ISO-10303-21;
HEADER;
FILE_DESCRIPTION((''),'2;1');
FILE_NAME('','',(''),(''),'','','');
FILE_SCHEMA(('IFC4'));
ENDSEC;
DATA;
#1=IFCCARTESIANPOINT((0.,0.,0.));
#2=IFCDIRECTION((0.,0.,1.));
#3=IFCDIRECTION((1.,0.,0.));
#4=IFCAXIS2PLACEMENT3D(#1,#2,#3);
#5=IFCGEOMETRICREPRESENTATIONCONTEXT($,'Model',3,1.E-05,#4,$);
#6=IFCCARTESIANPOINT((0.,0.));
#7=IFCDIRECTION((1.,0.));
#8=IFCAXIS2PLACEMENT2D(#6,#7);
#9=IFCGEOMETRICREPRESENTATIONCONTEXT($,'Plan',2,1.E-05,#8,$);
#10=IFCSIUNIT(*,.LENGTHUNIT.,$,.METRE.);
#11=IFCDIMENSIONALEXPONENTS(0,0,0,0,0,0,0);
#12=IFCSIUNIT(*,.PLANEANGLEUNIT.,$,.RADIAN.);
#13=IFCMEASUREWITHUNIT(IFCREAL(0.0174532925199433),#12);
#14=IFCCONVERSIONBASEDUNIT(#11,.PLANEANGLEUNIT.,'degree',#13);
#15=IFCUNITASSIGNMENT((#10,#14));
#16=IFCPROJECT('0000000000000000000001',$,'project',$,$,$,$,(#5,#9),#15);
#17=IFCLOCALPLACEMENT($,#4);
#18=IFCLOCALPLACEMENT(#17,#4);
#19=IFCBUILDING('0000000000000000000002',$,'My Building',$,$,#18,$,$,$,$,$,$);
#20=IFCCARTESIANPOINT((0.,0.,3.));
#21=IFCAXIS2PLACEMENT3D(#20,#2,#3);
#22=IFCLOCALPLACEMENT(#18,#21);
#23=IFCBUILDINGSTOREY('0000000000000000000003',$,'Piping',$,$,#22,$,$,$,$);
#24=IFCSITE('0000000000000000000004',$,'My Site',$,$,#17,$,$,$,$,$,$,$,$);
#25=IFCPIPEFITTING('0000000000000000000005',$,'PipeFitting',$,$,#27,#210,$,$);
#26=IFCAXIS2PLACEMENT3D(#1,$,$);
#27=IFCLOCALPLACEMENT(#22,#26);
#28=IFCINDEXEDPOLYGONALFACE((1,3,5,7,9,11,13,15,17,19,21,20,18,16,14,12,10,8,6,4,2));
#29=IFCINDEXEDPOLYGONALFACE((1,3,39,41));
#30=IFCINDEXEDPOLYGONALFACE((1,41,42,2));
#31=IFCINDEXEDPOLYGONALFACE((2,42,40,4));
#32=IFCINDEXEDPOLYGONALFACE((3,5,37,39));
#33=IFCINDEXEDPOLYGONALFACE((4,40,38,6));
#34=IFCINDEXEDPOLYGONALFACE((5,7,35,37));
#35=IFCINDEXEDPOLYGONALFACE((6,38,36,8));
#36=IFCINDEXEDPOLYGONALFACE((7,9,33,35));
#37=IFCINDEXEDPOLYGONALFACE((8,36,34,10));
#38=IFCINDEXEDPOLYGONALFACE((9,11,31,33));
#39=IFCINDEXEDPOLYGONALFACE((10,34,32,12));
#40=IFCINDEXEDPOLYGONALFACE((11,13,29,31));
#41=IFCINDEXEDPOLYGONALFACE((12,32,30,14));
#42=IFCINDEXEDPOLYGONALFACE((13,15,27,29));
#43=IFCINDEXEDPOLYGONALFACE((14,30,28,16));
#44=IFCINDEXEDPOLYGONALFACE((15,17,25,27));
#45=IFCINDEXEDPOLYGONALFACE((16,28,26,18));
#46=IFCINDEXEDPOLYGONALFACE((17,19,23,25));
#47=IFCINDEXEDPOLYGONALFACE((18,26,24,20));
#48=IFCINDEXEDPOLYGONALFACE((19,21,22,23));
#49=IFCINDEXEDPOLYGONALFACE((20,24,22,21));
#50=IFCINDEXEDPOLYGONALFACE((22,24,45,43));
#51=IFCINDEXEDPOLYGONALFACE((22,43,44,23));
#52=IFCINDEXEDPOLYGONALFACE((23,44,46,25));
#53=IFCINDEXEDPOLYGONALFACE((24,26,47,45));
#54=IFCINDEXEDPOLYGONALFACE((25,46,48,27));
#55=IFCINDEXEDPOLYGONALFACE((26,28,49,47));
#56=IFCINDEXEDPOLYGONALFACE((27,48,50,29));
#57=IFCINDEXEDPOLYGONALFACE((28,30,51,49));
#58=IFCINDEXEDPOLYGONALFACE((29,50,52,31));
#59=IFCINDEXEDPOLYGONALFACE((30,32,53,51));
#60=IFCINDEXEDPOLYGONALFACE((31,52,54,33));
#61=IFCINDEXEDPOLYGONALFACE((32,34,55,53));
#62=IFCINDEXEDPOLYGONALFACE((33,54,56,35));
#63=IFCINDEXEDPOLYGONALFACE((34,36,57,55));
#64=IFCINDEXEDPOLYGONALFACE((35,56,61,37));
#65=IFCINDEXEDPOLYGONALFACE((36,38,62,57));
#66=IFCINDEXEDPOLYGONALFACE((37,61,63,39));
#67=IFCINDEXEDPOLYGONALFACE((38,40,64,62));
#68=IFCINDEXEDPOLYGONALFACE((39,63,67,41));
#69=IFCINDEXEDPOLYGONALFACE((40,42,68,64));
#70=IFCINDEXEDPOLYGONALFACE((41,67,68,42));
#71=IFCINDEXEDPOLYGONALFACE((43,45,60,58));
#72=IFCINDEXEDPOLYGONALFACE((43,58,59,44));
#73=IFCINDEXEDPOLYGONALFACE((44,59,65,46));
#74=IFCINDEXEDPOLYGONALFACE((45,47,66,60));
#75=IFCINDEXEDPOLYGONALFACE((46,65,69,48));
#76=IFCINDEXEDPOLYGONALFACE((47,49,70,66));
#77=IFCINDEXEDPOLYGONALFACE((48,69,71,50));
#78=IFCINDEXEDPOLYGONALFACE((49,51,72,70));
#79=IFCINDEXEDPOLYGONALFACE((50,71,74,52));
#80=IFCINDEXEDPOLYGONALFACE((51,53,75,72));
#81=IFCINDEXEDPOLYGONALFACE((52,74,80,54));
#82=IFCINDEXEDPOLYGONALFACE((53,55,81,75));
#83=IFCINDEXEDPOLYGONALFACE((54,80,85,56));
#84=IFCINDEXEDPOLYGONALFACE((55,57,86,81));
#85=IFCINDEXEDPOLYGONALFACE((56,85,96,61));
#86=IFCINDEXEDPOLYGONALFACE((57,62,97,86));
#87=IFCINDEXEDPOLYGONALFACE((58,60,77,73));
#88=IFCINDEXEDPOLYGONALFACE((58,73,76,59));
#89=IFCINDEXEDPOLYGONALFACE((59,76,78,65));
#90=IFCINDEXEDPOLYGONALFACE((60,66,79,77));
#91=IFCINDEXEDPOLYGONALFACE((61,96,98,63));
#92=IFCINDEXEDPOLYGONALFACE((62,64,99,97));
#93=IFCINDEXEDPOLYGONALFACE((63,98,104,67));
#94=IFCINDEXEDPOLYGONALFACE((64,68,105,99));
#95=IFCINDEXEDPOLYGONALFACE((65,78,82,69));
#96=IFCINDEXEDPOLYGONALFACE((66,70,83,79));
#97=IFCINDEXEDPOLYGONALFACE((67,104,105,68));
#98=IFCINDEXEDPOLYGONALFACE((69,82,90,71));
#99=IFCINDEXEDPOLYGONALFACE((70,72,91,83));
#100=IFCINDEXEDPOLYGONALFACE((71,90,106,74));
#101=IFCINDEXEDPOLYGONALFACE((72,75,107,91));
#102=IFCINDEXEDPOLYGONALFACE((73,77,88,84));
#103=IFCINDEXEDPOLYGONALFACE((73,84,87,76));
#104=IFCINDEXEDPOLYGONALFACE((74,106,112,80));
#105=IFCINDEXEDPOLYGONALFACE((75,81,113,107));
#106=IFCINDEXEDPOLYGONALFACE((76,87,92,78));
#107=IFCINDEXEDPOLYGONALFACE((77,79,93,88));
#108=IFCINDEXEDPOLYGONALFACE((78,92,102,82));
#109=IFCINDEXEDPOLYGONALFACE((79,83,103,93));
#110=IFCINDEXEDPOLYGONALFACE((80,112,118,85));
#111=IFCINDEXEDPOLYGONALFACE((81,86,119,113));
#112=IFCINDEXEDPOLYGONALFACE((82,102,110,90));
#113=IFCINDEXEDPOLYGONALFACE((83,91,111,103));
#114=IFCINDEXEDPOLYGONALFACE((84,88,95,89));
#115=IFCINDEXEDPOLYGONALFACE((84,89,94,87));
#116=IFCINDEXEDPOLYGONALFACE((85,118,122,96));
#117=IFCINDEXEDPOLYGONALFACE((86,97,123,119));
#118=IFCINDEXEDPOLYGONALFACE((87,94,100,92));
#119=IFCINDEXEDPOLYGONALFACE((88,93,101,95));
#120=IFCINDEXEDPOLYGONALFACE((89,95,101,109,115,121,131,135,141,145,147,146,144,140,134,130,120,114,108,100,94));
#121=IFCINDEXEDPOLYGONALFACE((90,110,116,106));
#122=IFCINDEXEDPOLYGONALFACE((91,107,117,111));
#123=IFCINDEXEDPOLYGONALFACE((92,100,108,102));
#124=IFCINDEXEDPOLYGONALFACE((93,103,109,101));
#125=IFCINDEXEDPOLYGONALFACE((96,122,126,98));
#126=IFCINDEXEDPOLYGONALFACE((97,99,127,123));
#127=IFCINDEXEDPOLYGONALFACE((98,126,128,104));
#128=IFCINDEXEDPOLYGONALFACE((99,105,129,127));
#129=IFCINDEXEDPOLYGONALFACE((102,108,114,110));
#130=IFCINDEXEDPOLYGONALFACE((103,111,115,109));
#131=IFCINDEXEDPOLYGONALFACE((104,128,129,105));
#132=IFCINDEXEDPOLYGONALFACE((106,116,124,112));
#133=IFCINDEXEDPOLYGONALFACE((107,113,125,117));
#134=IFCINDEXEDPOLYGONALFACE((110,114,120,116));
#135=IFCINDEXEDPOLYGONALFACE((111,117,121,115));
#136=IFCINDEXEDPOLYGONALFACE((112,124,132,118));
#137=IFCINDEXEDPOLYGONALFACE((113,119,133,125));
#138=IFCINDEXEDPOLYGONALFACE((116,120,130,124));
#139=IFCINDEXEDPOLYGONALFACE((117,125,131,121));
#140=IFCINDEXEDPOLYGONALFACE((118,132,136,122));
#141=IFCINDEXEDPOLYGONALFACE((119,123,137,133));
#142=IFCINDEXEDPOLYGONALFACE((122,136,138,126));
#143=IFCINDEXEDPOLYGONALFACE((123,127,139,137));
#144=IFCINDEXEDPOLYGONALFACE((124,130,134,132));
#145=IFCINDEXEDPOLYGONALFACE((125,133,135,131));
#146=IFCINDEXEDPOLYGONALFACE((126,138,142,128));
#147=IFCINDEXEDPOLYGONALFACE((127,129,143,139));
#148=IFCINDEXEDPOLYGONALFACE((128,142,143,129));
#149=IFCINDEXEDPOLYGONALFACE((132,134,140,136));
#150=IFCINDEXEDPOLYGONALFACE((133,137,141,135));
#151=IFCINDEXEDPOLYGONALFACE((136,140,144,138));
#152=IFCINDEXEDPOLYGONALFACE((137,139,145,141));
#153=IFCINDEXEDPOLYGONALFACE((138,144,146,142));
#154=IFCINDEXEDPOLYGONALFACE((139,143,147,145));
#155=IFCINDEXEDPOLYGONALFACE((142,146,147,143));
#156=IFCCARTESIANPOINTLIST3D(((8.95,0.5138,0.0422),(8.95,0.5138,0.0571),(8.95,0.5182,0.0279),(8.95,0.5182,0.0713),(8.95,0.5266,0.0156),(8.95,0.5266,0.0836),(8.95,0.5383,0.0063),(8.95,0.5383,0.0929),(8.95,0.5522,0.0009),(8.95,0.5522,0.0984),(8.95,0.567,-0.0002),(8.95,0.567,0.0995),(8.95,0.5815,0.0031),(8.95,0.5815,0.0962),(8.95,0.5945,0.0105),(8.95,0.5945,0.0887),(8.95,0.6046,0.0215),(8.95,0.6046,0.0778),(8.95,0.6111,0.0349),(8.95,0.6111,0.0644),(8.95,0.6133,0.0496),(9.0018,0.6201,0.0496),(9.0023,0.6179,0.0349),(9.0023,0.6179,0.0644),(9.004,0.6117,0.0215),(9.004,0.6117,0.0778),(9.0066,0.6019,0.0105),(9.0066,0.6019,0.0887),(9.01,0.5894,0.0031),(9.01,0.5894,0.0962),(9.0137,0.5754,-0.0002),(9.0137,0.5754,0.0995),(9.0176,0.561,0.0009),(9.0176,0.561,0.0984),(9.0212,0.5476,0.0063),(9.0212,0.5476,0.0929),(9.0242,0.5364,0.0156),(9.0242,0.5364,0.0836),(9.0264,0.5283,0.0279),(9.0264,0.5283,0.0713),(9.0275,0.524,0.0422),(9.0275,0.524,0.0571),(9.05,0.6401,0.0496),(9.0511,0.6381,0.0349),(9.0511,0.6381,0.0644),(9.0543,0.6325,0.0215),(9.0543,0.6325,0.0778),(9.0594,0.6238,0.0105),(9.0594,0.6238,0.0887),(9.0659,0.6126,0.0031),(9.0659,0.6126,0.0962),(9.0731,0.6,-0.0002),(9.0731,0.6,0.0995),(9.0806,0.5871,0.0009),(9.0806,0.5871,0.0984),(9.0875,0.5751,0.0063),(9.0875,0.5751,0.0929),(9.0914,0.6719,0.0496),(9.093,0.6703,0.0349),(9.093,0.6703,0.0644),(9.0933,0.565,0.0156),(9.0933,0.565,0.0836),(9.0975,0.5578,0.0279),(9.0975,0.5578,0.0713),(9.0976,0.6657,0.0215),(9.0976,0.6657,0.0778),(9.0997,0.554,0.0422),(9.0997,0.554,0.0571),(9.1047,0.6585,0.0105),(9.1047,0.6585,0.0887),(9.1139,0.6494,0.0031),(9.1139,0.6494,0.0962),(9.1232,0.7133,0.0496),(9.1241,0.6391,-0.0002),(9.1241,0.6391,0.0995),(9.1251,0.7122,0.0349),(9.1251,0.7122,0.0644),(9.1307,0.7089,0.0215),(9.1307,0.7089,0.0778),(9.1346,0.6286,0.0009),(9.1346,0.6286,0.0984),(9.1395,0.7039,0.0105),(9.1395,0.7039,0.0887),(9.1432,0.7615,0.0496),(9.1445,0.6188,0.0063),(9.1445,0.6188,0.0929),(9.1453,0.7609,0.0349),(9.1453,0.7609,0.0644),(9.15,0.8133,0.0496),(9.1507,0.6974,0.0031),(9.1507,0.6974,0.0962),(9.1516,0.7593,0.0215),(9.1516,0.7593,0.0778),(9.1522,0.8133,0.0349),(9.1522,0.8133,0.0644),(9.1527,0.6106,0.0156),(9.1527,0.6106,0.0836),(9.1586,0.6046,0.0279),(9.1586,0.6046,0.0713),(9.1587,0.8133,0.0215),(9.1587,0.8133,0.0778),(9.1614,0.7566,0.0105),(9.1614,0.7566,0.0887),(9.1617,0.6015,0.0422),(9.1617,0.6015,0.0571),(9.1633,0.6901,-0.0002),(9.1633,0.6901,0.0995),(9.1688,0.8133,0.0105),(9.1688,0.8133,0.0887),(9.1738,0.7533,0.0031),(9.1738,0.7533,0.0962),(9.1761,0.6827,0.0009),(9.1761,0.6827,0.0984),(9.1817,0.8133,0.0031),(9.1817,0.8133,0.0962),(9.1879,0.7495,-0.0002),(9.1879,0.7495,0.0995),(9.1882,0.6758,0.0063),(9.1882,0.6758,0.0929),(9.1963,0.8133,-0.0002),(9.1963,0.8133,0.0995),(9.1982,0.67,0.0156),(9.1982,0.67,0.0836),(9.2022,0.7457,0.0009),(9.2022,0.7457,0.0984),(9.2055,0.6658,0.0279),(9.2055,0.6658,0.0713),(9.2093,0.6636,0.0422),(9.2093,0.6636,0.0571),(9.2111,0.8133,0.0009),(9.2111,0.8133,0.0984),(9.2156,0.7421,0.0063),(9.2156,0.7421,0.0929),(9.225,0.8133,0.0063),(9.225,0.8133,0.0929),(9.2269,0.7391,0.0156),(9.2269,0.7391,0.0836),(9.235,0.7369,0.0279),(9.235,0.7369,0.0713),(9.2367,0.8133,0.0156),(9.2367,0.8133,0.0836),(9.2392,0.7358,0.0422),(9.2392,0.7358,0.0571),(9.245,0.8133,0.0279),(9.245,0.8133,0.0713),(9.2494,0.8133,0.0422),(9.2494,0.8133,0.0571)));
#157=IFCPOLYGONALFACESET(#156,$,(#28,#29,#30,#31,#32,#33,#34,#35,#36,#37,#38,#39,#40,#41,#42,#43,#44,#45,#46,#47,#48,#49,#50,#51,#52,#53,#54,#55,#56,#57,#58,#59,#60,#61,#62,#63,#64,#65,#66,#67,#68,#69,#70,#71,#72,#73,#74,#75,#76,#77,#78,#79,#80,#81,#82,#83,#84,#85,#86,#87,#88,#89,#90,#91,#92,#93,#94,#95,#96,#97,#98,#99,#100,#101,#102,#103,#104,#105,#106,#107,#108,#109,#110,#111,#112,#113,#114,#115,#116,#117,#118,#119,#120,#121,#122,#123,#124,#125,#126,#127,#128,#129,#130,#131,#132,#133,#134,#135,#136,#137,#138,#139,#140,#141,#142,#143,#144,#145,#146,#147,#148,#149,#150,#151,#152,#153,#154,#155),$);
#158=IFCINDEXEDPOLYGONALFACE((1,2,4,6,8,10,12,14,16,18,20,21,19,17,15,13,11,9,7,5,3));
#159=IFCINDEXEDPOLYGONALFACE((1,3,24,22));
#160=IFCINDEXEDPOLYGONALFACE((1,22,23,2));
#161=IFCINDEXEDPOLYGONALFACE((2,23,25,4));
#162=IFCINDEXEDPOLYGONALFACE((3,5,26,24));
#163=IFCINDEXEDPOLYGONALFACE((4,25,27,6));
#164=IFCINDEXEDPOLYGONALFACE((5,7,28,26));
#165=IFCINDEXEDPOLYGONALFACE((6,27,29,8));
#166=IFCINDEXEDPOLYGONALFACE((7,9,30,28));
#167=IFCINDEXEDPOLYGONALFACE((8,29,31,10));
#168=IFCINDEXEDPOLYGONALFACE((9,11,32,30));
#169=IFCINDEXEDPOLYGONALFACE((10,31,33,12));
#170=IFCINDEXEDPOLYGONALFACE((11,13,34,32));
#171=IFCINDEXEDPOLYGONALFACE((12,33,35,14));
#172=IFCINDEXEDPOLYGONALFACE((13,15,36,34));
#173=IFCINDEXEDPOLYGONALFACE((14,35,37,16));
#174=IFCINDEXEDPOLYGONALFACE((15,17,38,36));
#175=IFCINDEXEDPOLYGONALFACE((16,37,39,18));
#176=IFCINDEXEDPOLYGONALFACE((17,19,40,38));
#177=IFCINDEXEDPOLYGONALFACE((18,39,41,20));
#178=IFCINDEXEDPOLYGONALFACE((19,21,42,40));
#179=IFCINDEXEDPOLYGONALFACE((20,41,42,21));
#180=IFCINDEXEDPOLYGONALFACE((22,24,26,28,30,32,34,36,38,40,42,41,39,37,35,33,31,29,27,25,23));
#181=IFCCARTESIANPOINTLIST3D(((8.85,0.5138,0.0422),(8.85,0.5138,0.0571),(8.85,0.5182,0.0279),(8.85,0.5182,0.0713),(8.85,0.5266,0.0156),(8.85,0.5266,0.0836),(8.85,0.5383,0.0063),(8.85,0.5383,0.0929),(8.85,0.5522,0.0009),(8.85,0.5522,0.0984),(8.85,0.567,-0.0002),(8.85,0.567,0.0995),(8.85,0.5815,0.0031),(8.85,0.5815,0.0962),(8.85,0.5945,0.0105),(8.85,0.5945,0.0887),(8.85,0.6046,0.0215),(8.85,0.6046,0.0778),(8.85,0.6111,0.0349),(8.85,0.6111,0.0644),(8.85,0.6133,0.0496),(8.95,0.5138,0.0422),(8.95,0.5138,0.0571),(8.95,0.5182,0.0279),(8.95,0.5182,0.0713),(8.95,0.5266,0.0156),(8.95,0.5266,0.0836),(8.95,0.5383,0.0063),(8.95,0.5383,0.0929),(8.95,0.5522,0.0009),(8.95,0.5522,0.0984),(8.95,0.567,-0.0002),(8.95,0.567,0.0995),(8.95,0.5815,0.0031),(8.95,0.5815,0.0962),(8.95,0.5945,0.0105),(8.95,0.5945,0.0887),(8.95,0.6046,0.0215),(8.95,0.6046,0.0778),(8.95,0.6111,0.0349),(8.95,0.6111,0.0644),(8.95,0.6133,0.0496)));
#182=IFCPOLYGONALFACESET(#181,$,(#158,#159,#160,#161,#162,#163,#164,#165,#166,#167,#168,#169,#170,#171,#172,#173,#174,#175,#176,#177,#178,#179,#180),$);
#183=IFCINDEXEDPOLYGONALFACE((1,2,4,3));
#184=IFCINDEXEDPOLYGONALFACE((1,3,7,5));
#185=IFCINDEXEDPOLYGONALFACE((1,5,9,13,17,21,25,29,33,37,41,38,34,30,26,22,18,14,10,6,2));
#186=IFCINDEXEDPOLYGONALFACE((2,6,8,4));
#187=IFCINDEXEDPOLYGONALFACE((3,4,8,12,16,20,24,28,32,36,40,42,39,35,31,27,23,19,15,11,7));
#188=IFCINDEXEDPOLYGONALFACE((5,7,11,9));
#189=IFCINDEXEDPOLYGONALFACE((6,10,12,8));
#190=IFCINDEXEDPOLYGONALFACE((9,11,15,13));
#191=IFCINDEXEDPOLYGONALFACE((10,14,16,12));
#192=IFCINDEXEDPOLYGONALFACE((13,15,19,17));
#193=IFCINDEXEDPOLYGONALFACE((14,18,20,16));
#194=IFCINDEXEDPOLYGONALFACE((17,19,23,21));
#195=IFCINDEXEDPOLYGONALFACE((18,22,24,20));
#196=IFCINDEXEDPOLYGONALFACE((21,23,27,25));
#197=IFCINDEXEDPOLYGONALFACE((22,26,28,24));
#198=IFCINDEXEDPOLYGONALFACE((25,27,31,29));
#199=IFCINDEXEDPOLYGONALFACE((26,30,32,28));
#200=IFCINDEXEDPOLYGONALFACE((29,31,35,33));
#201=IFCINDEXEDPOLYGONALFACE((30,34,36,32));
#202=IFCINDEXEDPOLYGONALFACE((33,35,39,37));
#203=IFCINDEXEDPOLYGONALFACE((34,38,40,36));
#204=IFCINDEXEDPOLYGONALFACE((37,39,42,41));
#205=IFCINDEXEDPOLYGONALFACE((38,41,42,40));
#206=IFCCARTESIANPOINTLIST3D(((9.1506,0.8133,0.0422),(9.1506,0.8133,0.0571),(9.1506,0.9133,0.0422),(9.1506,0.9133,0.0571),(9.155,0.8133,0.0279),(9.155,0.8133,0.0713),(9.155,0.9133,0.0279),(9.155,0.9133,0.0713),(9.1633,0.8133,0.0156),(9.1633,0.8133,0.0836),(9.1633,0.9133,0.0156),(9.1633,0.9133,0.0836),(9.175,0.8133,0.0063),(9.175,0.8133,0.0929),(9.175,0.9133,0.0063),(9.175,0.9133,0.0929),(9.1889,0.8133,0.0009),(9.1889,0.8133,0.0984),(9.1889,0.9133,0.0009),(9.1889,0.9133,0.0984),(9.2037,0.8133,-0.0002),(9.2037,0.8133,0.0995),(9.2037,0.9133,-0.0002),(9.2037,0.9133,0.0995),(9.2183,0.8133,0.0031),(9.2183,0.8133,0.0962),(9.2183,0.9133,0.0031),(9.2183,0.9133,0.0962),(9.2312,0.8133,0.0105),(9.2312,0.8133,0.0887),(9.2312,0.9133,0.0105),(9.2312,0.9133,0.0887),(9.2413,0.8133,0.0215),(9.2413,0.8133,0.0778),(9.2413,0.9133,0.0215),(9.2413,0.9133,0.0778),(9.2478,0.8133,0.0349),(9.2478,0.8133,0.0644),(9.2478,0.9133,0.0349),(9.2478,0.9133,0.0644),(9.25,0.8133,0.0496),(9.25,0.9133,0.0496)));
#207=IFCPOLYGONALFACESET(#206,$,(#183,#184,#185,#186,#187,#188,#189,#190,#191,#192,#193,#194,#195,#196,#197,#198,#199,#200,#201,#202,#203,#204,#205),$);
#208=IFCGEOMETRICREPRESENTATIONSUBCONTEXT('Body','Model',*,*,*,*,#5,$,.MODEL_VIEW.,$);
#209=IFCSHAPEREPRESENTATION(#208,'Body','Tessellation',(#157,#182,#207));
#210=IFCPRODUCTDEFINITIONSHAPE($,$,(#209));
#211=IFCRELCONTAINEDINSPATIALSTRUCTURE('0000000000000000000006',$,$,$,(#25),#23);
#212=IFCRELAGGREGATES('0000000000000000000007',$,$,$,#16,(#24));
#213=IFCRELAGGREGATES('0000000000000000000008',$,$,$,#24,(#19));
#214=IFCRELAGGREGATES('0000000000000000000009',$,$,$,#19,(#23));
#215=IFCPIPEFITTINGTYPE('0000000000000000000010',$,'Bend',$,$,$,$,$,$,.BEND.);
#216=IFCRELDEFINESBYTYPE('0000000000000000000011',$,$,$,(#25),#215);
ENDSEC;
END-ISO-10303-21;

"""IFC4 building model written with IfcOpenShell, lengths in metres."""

from ifc_helpers import new_model, entity, si_unit, converted_unit, frame, origin_with_axes, origin_2d_with_axis, place, context, subcontext, project, spatial, circle, extrude, source, transform, mapped, type_object, type_shapes, element, save


model = new_model("IFC4")

# Units and contexts
model_context = context("Model", 3, precision=1e-05, world=origin_with_axes())
plan_context = context("Plan", 2, precision=1e-05, world=origin_2d_with_axis())
body_context = subcontext(model_context, "Body", "Model", "MODEL_VIEW")
ifc_project = project(units=[si_unit("LENGTHUNIT", "METRE"), converted_unit("PLANEANGLEUNIT", "degree", entity("IfcReal", 0.0174532925199433), si_unit("PLANEANGLEUNIT", "RADIAN"), dimensions=[0, 0, 0, 0, 0, 0, 0])], contexts=[model_context, plan_context])

# Site, building, storey
site_placement = place(None, origin_with_axes())
site = spatial("IfcSite", under=ifc_project, at=site_placement, Name="My Site")
building_placement = place(site_placement, origin_with_axes())
building = spatial("IfcBuilding", under=site, at=building_placement, Name="My Building")
storey_placement = place(building_placement, frame((0.0, 0.0, 3.0), z_axis=(0.0, 0.0, 1.0), x_axis=(1.0, 0.0, 0.0)))
storey = spatial("IfcBuildingStorey", under=building, at=storey_placement, Name="Piping")

# Pipe fitting
pipe_fitting_type_1 = type_object("IfcPipeFittingType", Name="Bend", PredefinedType="BEND")
shared_shape_1 = source(origin_with_axes(), body_context, "Body", "SolidModel", [
    entity("IfcSweptDiskSolid", entity("IfcIndexedPolyCurve", entity("IfcCartesianPointList3D", [[0.0, 0.0, 0.1], [0.0732, 0.0, 0.2768], [0.25, 0.0, 0.35]]), [entity("IfcArcIndex", [1, 2, 3])]), 0.05),
    extrude(circle(Radius=0.05), origin_with_axes(), (0.0, 0.0, 1.0), 0.1),
    extrude(circle(Radius=0.05), frame((0.25, 0.0, 0.35), z_axis=(1.0, 0.0, 0.0), x_axis=(0.0, 0.0, 1.0)), (0.0, 0.0, 1.0), 0.1),
])
type_shapes(pipe_fitting_type_1, [shared_shape_1])
for number, where, z_axis, x_axis, name in (
    (1, (8.85, 0.5633, 0.0496), (1.0, 0.0, 0.0), (0.0, 1.0, 0.0), "PipeFitting"),
):
    element("IfcPipeFitting", number, at=place(storey_placement, frame(where, z_axis=z_axis, x_axis=x_axis)), inside=storey, type_object=pipe_fitting_type_1, Name=name, context=body_context, shape_type="MappedRepresentation", body=[
        mapped(shared_shape_1, transform((0.0, 0.0, 0.0), x_axis=(1.0, 0.0, 0.0), y_axis=(0.0, 1.0, 0.0), z_axis=(0.0, 0.0, 1.0), scale=1.0)),
    ])

save(model, "model.ifc")
